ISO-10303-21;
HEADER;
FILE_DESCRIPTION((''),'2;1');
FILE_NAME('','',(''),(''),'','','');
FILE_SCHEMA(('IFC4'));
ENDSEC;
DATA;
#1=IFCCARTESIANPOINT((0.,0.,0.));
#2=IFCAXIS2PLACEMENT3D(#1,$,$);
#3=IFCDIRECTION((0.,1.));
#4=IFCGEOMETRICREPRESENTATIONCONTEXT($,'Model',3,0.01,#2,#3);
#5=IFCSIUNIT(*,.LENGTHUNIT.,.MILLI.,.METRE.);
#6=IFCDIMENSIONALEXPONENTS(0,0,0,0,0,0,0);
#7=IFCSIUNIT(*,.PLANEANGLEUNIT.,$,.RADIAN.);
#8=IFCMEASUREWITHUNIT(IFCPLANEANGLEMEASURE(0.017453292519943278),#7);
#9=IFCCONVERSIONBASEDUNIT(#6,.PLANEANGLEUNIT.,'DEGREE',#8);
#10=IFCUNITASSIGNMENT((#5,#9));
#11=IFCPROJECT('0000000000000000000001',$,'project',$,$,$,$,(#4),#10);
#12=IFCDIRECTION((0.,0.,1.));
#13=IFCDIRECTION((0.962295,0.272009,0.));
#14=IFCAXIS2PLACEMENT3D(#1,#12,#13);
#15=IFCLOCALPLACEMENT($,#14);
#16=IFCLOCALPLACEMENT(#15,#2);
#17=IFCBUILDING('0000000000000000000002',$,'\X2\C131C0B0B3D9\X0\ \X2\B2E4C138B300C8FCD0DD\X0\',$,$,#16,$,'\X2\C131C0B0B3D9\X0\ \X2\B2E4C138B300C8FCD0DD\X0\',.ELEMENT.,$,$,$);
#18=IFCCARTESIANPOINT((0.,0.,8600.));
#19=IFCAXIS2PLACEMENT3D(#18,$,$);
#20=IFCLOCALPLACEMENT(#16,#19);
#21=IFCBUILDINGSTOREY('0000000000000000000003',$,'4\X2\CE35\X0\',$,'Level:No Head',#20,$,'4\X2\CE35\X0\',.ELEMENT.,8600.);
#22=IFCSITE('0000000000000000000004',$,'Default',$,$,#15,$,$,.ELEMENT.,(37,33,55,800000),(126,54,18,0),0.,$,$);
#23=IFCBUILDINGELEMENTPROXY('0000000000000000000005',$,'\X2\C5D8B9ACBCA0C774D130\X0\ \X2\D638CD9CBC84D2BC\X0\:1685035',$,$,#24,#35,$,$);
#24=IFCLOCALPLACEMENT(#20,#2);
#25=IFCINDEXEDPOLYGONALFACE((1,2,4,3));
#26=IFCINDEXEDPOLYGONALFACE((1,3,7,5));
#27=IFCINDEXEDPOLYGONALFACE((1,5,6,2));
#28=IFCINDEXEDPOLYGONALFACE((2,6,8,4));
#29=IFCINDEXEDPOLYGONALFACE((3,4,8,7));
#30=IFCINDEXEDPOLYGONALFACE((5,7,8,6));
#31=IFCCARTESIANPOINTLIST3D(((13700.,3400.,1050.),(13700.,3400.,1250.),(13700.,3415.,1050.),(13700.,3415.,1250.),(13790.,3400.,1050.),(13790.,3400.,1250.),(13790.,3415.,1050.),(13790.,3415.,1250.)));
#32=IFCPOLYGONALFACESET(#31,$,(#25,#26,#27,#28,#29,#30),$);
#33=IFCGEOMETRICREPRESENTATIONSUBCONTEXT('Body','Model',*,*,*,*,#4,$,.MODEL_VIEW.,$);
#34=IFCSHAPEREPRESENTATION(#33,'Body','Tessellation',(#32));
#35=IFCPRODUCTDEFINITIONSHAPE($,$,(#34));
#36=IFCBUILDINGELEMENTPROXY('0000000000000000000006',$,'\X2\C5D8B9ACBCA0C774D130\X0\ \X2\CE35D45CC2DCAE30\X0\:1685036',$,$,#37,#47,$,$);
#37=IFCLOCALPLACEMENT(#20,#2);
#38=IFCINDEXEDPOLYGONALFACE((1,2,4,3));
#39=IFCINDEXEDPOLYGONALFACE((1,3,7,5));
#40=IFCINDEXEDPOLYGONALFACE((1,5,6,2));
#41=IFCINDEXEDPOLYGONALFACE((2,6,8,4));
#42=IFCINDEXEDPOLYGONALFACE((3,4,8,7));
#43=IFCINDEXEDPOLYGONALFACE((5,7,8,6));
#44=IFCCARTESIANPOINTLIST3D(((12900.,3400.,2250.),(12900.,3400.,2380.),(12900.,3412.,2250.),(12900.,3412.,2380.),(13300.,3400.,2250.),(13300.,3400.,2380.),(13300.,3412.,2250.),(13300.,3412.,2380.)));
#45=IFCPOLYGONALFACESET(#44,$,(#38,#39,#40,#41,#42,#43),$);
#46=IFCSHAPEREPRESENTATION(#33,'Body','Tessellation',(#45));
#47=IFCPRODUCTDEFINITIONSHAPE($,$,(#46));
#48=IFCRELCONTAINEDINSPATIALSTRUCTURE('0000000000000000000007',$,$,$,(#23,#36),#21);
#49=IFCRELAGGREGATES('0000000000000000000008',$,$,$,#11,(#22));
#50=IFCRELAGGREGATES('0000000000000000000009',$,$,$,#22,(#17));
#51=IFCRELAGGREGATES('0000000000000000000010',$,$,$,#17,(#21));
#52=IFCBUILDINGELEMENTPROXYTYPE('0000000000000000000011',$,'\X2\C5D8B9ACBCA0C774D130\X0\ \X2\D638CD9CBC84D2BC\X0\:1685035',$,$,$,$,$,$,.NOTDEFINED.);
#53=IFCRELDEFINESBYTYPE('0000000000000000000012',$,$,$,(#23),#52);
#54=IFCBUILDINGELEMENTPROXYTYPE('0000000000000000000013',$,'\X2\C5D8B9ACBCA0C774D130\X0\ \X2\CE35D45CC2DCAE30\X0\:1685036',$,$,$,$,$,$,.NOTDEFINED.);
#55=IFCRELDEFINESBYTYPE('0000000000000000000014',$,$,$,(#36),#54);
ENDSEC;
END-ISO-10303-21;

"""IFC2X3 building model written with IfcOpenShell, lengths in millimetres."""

from ifc_helpers import new_model, entity, si_unit, converted_unit, direction, frame, frame_2d, origin, place, context, subcontext, project, spatial, rectangle, extrude, type_object, element, save


model = new_model("IFC2X3")

# Units and contexts
model_context = context("Model", 3, precision=0.01, world=origin(), true_north=direction((0.0, 1.0)))
body_context = subcontext(model_context, "Body", "Model", "MODEL_VIEW")
ifc_project = project(units=[si_unit("LENGTHUNIT", "METRE", prefix="MILLI"), converted_unit("PLANEANGLEUNIT", "DEGREE", entity("IfcPlaneAngleMeasure", 0.017453292519943278), si_unit("PLANEANGLEUNIT", "RADIAN"), dimensions=[0, 0, 0, 0, 0, 0, 0])], contexts=[model_context])

# Site, building, storey
site_placement = place(None, frame((0.0, 0.0, 0.0), z_axis=(0.0, 0.0, 1.0), x_axis=(0.962295, 0.272009, 0.0)))
site = spatial("IfcSite", under=ifc_project, at=site_placement, Name="Default", CompositionType="ELEMENT", RefLatitude=(37, 33, 55, 800000), RefLongitude=(126, 54, 18, 0), RefElevation=0.0)
building_placement = place(site_placement, origin())
building = spatial("IfcBuilding", under=site, at=building_placement, Name="성산동 다세대주택", LongName="성산동 다세대주택", CompositionType="ELEMENT")
storey_placement = place(building_placement, frame((0.0, 0.0, 8600.0)))
storey = spatial("IfcBuildingStorey", under=building, at=storey_placement, Name="4층", ObjectType="Level:No Head", LongName="4층", CompositionType="ELEMENT", Elevation=8600.0)

# Building element proxies
building_element_proxy_type_1 = type_object("IfcBuildingElementProxyType", Name="엘리베이터 호출버튼:1685035", PredefinedType="NOTDEFINED")
proxy_1_placement = place(storey_placement, origin())
element("IfcBuildingElementProxy", 1, at=proxy_1_placement, inside=storey, type_object=building_element_proxy_type_1, Name="엘리베이터 호출버튼:1685035", context=body_context, shape_type="SweptSolid", body=[
    extrude(rectangle(XDim=90.0, YDim=15.0, at=frame_2d((0.0, 0.0), x_axis=(1.0, 0.0))), frame((13745.0, 3407.5, 1050.0)), (0.0, 0.0, 1.0), 200.0),
])
building_element_proxy_type_2 = type_object("IfcBuildingElementProxyType", Name="엘리베이터 층표시기:1685036", PredefinedType="NOTDEFINED")
proxy_2_placement = place(storey_placement, origin())
element("IfcBuildingElementProxy", 2, at=proxy_2_placement, inside=storey, type_object=building_element_proxy_type_2, Name="엘리베이터 층표시기:1685036", context=body_context, shape_type="SweptSolid", body=[
    extrude(rectangle(XDim=400.0, YDim=12.0, at=frame_2d((0.0, 0.0), x_axis=(1.0, 0.0))), frame((13100.0, 3406.0, 2250.0)), (0.0, 0.0, 1.0), 130.0),
])

save(model, "model.ifc")
